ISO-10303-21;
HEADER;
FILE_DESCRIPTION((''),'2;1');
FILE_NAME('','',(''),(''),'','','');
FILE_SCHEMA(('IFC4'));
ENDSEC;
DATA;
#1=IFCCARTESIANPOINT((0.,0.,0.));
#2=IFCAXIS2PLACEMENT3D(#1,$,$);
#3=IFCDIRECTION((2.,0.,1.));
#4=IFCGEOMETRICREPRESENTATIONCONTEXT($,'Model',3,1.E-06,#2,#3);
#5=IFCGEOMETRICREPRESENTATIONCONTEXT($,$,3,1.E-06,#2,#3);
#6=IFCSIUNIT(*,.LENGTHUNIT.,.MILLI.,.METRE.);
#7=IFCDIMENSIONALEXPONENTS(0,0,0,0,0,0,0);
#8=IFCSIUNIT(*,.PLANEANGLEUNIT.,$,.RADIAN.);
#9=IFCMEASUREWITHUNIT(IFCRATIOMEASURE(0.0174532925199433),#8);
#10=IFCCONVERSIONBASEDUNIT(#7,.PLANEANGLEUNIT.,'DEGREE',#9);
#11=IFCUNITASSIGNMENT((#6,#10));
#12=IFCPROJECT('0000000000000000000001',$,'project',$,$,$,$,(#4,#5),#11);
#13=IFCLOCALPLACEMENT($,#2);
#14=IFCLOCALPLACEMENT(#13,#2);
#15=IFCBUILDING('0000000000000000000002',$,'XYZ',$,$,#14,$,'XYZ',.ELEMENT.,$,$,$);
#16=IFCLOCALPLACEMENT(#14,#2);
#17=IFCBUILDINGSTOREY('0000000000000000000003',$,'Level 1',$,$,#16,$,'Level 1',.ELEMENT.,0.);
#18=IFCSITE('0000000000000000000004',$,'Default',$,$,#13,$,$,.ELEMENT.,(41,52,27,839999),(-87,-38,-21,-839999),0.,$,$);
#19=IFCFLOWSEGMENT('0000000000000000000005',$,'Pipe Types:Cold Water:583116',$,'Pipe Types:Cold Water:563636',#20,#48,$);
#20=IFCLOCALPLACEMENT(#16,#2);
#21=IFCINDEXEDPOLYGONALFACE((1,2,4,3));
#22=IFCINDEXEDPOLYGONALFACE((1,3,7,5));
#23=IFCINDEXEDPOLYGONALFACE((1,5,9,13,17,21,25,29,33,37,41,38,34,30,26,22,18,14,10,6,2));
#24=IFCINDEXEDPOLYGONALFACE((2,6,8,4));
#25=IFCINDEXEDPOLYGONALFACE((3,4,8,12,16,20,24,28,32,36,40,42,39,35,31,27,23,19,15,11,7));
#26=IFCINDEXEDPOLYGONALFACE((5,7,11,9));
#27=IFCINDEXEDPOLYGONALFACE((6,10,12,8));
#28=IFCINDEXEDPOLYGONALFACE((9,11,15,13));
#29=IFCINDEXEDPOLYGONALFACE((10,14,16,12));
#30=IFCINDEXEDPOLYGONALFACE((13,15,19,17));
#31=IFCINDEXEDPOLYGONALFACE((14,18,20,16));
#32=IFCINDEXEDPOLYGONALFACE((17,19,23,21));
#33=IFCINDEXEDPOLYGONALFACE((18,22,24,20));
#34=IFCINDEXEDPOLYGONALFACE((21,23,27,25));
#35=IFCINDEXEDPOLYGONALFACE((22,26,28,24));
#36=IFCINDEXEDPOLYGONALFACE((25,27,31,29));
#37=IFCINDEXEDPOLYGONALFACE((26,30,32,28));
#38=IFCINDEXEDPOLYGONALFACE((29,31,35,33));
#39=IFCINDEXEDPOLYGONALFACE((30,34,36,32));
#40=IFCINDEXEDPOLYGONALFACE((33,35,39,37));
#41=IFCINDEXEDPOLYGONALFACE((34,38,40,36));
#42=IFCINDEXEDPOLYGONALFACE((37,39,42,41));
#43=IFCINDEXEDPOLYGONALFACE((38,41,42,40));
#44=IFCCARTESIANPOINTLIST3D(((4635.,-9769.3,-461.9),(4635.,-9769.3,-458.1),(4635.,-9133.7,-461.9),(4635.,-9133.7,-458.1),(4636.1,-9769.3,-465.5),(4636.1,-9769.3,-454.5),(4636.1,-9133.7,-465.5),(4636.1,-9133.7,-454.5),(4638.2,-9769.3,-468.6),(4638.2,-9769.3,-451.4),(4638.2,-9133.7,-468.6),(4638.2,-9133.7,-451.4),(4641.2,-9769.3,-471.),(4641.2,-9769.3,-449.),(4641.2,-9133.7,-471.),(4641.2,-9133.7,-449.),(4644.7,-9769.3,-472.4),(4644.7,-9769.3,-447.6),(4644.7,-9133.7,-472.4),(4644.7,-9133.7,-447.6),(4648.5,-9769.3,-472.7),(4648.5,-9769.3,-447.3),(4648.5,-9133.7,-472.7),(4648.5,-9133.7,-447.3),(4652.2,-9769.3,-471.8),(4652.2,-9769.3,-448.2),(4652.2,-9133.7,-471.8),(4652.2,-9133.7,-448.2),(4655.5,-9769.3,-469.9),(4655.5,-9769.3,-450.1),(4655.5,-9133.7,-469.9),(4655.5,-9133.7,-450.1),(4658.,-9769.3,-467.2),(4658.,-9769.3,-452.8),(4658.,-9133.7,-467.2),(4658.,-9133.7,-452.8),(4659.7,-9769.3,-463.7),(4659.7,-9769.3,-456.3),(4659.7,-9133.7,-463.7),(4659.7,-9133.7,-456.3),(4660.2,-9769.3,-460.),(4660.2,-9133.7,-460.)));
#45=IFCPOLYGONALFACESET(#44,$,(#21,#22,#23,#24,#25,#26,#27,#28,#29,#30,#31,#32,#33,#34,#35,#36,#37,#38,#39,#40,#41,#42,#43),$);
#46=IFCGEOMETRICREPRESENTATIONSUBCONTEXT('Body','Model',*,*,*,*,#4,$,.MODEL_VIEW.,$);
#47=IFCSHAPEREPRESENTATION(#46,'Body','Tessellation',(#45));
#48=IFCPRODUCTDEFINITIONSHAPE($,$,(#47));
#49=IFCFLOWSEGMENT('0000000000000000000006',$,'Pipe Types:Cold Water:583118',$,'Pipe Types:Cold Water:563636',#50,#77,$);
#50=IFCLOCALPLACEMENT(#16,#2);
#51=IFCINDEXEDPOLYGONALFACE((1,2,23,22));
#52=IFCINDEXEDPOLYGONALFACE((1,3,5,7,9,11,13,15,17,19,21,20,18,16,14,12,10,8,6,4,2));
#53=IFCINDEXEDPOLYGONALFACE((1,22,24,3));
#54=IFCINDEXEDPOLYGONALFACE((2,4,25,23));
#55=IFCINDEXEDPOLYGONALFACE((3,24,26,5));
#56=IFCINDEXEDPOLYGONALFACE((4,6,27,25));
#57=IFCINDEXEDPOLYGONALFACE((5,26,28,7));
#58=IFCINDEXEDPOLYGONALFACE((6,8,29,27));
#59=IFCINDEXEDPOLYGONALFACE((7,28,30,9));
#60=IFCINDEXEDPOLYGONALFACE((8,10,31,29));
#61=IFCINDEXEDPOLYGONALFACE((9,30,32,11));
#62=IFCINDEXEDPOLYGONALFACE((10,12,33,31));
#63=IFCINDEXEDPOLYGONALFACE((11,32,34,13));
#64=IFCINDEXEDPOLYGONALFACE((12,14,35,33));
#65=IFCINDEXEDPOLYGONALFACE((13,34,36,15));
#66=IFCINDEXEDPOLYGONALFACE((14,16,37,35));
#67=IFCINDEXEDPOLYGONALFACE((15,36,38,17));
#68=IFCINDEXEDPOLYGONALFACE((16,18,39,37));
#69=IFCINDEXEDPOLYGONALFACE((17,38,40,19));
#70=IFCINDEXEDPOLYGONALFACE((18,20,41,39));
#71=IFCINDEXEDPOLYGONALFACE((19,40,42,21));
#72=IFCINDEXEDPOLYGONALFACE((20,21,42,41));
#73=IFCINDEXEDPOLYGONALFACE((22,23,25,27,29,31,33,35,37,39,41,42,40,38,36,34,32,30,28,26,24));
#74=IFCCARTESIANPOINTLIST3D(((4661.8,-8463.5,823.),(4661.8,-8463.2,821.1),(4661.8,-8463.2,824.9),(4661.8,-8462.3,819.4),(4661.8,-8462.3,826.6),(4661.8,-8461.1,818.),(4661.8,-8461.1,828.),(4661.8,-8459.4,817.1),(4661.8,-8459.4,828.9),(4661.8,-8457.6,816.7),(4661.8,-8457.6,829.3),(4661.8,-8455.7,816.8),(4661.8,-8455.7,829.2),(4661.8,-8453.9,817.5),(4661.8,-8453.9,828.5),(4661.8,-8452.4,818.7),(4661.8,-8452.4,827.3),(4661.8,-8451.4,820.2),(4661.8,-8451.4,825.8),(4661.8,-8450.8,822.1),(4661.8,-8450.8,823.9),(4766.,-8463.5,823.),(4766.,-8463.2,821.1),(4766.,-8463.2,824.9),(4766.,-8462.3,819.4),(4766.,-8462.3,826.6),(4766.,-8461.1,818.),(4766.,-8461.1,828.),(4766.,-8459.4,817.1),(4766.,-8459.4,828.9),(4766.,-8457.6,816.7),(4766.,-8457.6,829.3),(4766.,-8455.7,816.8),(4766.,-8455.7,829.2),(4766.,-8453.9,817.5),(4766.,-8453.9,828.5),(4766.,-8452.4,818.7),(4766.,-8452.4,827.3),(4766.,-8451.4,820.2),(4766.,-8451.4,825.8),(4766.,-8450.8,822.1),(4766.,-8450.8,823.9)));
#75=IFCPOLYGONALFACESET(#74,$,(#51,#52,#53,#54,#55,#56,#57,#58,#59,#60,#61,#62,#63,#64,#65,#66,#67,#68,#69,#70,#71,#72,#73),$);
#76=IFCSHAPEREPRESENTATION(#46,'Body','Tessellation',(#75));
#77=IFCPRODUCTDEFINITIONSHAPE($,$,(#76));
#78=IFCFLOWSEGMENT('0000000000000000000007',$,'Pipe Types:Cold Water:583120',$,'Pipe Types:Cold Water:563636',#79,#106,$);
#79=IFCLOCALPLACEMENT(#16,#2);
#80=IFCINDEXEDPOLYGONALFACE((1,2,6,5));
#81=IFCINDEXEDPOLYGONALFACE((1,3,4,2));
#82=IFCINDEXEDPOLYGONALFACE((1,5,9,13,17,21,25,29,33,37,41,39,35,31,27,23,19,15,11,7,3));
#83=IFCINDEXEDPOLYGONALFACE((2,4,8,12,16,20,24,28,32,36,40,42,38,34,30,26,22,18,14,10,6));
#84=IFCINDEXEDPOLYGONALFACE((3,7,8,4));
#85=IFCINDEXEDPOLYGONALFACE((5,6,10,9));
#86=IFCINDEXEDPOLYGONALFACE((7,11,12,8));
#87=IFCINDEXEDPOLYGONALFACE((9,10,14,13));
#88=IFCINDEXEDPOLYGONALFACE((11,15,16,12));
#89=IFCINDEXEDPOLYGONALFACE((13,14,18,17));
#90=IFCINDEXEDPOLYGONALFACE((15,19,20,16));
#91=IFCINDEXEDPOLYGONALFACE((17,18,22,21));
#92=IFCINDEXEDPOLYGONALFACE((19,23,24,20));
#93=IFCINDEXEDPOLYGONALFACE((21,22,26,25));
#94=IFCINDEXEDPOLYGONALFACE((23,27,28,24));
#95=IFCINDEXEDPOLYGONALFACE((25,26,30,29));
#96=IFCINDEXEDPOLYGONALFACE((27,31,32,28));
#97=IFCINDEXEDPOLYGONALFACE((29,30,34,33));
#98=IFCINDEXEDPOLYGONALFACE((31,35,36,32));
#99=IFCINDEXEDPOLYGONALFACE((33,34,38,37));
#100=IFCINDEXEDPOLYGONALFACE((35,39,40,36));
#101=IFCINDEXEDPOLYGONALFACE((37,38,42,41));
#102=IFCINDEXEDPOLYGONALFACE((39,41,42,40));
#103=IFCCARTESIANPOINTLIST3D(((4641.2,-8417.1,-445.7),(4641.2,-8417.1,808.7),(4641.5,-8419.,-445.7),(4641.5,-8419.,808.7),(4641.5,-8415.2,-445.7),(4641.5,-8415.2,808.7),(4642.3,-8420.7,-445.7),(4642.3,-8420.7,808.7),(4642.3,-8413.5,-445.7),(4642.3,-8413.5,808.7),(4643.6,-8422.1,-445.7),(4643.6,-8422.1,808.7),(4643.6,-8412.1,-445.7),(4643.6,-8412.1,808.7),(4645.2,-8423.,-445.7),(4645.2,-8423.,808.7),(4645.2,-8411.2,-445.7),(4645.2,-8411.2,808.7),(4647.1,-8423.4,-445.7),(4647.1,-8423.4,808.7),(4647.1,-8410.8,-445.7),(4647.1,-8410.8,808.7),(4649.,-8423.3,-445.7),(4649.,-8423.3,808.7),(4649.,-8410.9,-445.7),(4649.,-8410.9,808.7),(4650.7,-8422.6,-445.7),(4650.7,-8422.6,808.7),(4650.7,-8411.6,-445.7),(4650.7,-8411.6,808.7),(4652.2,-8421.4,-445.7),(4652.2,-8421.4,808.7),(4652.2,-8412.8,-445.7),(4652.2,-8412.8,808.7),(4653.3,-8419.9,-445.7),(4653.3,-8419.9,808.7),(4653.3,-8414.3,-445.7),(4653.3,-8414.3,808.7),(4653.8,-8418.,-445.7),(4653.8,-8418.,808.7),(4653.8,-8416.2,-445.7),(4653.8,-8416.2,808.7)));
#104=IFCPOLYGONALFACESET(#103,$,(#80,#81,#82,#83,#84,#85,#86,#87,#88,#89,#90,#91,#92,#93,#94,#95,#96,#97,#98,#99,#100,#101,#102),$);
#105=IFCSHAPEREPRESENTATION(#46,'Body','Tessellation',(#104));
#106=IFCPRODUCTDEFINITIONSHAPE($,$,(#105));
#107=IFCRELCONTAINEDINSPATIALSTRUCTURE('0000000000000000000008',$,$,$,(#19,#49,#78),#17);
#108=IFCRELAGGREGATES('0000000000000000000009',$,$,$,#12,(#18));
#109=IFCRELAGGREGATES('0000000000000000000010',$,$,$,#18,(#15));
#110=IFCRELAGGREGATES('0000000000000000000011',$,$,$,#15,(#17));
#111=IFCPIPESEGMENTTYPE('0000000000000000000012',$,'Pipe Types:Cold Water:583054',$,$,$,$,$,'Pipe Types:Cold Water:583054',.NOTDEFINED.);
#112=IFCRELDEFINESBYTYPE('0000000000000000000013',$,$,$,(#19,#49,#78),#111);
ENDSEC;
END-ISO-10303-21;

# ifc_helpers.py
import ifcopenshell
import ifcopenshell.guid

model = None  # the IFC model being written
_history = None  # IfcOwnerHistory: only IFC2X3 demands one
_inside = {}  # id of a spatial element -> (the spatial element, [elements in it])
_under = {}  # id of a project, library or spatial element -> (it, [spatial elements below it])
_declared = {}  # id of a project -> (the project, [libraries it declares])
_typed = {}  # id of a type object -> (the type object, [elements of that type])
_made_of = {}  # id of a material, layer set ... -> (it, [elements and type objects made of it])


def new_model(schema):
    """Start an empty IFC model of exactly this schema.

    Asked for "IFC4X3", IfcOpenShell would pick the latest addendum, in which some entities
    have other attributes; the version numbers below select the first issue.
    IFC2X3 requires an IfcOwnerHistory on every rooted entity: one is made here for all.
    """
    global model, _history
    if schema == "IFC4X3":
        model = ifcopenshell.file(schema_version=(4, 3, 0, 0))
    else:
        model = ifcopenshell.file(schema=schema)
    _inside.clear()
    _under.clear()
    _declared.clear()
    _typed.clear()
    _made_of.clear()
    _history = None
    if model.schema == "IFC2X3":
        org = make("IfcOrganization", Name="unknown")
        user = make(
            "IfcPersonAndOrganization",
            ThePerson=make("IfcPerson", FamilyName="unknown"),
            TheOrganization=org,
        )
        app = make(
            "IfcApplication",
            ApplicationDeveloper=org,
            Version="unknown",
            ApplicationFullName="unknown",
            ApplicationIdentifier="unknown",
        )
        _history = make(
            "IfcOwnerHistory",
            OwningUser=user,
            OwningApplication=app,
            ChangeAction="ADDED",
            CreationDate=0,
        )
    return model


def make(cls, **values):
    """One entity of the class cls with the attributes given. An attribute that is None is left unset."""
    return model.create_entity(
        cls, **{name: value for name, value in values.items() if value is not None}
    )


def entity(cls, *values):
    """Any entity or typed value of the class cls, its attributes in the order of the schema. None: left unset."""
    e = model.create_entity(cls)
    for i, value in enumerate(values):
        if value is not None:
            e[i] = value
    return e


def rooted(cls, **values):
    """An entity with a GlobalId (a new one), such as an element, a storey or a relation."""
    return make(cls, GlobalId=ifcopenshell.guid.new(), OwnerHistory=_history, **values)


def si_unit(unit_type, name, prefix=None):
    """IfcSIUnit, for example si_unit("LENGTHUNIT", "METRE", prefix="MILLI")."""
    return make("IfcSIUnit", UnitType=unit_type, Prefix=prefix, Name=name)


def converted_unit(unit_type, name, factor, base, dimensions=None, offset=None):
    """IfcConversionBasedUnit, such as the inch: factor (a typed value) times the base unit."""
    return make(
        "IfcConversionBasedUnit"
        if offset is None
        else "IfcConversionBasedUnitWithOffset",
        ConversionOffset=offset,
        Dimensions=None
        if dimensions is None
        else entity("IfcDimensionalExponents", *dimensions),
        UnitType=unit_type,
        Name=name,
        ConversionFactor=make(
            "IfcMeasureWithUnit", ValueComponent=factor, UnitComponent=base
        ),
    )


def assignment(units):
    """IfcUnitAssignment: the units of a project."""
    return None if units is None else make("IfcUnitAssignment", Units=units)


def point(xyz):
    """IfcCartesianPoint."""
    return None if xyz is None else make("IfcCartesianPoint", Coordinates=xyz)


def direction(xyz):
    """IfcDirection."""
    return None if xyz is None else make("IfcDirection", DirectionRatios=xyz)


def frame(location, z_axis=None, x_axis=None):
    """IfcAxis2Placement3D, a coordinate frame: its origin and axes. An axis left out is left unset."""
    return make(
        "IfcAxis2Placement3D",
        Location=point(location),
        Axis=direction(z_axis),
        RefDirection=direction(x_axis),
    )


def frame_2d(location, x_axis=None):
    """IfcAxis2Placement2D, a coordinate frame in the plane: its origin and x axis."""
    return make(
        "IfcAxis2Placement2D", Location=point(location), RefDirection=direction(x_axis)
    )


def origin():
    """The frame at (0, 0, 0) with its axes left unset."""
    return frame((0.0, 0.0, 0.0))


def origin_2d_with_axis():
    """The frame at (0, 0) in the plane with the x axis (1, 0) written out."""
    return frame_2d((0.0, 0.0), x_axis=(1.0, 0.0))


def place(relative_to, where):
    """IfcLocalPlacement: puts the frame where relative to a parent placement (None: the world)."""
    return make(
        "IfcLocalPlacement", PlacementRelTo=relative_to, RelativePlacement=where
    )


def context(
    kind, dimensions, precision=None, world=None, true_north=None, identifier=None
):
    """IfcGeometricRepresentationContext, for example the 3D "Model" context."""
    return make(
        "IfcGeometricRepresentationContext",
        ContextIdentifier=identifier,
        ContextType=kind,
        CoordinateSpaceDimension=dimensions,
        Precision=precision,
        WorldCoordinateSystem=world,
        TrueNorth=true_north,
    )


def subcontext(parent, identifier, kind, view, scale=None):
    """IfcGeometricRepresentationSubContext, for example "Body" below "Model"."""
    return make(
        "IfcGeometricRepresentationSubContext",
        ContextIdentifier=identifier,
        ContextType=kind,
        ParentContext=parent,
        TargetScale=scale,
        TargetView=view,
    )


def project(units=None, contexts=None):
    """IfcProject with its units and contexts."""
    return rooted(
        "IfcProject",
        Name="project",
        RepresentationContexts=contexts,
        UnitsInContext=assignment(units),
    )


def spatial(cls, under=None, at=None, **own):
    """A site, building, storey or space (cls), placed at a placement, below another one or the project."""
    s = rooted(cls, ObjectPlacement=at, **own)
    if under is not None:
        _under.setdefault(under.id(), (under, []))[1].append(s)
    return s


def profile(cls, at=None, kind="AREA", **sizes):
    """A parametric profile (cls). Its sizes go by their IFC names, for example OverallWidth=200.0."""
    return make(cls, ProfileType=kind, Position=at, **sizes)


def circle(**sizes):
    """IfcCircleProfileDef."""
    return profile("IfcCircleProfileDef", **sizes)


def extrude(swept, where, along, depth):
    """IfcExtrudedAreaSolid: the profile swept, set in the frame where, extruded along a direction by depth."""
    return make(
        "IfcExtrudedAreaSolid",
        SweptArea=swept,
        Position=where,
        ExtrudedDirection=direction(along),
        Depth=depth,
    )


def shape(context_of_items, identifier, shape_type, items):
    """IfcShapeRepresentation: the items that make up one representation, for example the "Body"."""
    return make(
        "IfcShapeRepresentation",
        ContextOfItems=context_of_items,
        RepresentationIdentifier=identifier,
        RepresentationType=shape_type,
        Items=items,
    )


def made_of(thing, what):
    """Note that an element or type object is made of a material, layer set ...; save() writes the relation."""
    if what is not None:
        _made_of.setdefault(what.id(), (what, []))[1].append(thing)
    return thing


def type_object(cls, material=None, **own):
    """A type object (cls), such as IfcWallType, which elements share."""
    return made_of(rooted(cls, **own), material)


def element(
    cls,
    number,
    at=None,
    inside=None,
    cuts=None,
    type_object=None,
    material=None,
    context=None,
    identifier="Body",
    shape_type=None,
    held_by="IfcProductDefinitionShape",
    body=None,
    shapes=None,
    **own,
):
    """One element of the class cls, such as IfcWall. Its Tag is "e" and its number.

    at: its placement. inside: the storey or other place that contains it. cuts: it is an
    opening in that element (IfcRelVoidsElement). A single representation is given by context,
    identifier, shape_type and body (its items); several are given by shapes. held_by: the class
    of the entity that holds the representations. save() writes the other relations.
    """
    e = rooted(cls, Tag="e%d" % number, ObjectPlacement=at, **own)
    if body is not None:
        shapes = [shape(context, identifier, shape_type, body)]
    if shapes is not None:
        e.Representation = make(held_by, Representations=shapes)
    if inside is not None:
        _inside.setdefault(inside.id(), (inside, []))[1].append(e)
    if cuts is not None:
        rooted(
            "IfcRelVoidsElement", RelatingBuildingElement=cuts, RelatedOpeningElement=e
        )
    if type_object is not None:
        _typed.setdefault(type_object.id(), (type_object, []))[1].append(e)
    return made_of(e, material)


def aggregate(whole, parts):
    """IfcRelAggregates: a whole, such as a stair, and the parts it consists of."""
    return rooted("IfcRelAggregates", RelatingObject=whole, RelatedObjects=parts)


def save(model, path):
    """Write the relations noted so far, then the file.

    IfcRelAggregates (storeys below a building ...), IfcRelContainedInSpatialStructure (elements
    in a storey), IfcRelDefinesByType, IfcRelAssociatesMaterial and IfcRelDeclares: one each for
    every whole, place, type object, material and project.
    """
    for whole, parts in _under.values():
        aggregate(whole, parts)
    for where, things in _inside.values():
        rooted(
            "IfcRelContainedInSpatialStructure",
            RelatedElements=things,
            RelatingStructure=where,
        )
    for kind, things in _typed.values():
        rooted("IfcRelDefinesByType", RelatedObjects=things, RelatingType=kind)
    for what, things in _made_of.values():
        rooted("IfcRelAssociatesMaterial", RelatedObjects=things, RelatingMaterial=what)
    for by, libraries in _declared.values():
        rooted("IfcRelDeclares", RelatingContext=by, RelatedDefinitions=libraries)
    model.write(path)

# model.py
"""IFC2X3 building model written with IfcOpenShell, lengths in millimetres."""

from ifc_helpers import new_model, entity, si_unit, converted_unit, direction, frame, frame_2d, origin, origin_2d_with_axis, place, context, subcontext, project, spatial, circle, extrude, type_object, element, save


model = new_model("IFC2X3")

# Units and contexts
model_context = context("Model", 3, precision=1e-06, world=origin(), true_north=direction((2.0, 0.0, 1.0)))
context_of_model = context(None, 3, precision=1e-06, world=origin(), true_north=direction((2.0, 0.0, 1.0)))
body_context = subcontext(model_context, "Body", "Model", "MODEL_VIEW")
ifc_project = project(units=[si_unit("LENGTHUNIT", "METRE", prefix="MILLI"), converted_unit("PLANEANGLEUNIT", "DEGREE", entity("IfcRatioMeasure", 0.0174532925199433), si_unit("PLANEANGLEUNIT", "RADIAN"), dimensions=[0, 0, 0, 0, 0, 0, 0])], contexts=[model_context, context_of_model])

# Site, building, storey
site_placement = place(None, origin())
site = spatial("IfcSite", under=ifc_project, at=site_placement, Name="Default", CompositionType="ELEMENT", RefLatitude=(41, 52, 27, 839999), RefLongitude=(-87, -38, -21, -839999), RefElevation=0.0)
building_placement = place(site_placement, origin())
building = spatial("IfcBuilding", under=site, at=building_placement, Name="XYZ", LongName="XYZ", CompositionType="ELEMENT")
storey_placement = place(building_placement, origin())
storey = spatial("IfcBuildingStorey", under=building, at=storey_placement, Name="Level 1", LongName="Level 1", CompositionType="ELEMENT", Elevation=0.0)

# Flow segments
pipe_segment_type_1 = type_object("IfcPipeSegmentType", Name="Pipe Types:Cold Water:583054", ElementType="Pipe Types:Cold Water:583054", PredefinedType="NOTDEFINED")
flow_segment_1_placement = place(storey_placement, origin())
element("IfcFlowSegment", 1, at=flow_segment_1_placement, inside=storey, type_object=pipe_segment_type_1, Name="Pipe Types:Cold Water:583116", ObjectType="Pipe Types:Cold Water:563636", context=body_context, shape_type="SweptSolid", body=[
    extrude(circle(Radius=12.7, at=origin_2d_with_axis()), frame((4647.5, -9769.3, -460.0), z_axis=(0.0, 1.0, 0.0), x_axis=(1.0, 0.0, 0.0)), (0.0, 0.0, 1.0), 635.6),
])
flow_segment_2_placement = place(storey_placement, origin())
element("IfcFlowSegment", 2, at=flow_segment_2_placement, inside=storey, type_object=pipe_segment_type_1, Name="Pipe Types:Cold Water:583118", ObjectType="Pipe Types:Cold Water:563636", context=body_context, shape_type="SweptSolid", body=[
    extrude(circle(Radius=6.3, at=frame_2d((0.0, 0.0), x_axis=(1.0, 0.0))), frame((4661.8, -8457.1, 823.0), z_axis=(1.0, 0.0, 0.0), x_axis=(0.0, -1.0, 0.0)), (0.0, 0.0, 1.0), 104.2),
])
flow_segment_3_placement = place(storey_placement, origin())
element("IfcFlowSegment", 3, at=flow_segment_3_placement, inside=storey, type_object=pipe_segment_type_1, Name="Pipe Types:Cold Water:583120", ObjectType="Pipe Types:Cold Water:563636", context=body_context, shape_type="SweptSolid", body=[
    extrude(circle(Radius=6.3, at=origin_2d_with_axis()), frame((4647.5, -8417.1, -445.7), z_axis=(0.0, 0.0, 1.0), x_axis=(-1.0, 0.0, 0.0)), (0.0, 0.0, 1.0), 1254.4),
])

save(model, "model.ifc")
